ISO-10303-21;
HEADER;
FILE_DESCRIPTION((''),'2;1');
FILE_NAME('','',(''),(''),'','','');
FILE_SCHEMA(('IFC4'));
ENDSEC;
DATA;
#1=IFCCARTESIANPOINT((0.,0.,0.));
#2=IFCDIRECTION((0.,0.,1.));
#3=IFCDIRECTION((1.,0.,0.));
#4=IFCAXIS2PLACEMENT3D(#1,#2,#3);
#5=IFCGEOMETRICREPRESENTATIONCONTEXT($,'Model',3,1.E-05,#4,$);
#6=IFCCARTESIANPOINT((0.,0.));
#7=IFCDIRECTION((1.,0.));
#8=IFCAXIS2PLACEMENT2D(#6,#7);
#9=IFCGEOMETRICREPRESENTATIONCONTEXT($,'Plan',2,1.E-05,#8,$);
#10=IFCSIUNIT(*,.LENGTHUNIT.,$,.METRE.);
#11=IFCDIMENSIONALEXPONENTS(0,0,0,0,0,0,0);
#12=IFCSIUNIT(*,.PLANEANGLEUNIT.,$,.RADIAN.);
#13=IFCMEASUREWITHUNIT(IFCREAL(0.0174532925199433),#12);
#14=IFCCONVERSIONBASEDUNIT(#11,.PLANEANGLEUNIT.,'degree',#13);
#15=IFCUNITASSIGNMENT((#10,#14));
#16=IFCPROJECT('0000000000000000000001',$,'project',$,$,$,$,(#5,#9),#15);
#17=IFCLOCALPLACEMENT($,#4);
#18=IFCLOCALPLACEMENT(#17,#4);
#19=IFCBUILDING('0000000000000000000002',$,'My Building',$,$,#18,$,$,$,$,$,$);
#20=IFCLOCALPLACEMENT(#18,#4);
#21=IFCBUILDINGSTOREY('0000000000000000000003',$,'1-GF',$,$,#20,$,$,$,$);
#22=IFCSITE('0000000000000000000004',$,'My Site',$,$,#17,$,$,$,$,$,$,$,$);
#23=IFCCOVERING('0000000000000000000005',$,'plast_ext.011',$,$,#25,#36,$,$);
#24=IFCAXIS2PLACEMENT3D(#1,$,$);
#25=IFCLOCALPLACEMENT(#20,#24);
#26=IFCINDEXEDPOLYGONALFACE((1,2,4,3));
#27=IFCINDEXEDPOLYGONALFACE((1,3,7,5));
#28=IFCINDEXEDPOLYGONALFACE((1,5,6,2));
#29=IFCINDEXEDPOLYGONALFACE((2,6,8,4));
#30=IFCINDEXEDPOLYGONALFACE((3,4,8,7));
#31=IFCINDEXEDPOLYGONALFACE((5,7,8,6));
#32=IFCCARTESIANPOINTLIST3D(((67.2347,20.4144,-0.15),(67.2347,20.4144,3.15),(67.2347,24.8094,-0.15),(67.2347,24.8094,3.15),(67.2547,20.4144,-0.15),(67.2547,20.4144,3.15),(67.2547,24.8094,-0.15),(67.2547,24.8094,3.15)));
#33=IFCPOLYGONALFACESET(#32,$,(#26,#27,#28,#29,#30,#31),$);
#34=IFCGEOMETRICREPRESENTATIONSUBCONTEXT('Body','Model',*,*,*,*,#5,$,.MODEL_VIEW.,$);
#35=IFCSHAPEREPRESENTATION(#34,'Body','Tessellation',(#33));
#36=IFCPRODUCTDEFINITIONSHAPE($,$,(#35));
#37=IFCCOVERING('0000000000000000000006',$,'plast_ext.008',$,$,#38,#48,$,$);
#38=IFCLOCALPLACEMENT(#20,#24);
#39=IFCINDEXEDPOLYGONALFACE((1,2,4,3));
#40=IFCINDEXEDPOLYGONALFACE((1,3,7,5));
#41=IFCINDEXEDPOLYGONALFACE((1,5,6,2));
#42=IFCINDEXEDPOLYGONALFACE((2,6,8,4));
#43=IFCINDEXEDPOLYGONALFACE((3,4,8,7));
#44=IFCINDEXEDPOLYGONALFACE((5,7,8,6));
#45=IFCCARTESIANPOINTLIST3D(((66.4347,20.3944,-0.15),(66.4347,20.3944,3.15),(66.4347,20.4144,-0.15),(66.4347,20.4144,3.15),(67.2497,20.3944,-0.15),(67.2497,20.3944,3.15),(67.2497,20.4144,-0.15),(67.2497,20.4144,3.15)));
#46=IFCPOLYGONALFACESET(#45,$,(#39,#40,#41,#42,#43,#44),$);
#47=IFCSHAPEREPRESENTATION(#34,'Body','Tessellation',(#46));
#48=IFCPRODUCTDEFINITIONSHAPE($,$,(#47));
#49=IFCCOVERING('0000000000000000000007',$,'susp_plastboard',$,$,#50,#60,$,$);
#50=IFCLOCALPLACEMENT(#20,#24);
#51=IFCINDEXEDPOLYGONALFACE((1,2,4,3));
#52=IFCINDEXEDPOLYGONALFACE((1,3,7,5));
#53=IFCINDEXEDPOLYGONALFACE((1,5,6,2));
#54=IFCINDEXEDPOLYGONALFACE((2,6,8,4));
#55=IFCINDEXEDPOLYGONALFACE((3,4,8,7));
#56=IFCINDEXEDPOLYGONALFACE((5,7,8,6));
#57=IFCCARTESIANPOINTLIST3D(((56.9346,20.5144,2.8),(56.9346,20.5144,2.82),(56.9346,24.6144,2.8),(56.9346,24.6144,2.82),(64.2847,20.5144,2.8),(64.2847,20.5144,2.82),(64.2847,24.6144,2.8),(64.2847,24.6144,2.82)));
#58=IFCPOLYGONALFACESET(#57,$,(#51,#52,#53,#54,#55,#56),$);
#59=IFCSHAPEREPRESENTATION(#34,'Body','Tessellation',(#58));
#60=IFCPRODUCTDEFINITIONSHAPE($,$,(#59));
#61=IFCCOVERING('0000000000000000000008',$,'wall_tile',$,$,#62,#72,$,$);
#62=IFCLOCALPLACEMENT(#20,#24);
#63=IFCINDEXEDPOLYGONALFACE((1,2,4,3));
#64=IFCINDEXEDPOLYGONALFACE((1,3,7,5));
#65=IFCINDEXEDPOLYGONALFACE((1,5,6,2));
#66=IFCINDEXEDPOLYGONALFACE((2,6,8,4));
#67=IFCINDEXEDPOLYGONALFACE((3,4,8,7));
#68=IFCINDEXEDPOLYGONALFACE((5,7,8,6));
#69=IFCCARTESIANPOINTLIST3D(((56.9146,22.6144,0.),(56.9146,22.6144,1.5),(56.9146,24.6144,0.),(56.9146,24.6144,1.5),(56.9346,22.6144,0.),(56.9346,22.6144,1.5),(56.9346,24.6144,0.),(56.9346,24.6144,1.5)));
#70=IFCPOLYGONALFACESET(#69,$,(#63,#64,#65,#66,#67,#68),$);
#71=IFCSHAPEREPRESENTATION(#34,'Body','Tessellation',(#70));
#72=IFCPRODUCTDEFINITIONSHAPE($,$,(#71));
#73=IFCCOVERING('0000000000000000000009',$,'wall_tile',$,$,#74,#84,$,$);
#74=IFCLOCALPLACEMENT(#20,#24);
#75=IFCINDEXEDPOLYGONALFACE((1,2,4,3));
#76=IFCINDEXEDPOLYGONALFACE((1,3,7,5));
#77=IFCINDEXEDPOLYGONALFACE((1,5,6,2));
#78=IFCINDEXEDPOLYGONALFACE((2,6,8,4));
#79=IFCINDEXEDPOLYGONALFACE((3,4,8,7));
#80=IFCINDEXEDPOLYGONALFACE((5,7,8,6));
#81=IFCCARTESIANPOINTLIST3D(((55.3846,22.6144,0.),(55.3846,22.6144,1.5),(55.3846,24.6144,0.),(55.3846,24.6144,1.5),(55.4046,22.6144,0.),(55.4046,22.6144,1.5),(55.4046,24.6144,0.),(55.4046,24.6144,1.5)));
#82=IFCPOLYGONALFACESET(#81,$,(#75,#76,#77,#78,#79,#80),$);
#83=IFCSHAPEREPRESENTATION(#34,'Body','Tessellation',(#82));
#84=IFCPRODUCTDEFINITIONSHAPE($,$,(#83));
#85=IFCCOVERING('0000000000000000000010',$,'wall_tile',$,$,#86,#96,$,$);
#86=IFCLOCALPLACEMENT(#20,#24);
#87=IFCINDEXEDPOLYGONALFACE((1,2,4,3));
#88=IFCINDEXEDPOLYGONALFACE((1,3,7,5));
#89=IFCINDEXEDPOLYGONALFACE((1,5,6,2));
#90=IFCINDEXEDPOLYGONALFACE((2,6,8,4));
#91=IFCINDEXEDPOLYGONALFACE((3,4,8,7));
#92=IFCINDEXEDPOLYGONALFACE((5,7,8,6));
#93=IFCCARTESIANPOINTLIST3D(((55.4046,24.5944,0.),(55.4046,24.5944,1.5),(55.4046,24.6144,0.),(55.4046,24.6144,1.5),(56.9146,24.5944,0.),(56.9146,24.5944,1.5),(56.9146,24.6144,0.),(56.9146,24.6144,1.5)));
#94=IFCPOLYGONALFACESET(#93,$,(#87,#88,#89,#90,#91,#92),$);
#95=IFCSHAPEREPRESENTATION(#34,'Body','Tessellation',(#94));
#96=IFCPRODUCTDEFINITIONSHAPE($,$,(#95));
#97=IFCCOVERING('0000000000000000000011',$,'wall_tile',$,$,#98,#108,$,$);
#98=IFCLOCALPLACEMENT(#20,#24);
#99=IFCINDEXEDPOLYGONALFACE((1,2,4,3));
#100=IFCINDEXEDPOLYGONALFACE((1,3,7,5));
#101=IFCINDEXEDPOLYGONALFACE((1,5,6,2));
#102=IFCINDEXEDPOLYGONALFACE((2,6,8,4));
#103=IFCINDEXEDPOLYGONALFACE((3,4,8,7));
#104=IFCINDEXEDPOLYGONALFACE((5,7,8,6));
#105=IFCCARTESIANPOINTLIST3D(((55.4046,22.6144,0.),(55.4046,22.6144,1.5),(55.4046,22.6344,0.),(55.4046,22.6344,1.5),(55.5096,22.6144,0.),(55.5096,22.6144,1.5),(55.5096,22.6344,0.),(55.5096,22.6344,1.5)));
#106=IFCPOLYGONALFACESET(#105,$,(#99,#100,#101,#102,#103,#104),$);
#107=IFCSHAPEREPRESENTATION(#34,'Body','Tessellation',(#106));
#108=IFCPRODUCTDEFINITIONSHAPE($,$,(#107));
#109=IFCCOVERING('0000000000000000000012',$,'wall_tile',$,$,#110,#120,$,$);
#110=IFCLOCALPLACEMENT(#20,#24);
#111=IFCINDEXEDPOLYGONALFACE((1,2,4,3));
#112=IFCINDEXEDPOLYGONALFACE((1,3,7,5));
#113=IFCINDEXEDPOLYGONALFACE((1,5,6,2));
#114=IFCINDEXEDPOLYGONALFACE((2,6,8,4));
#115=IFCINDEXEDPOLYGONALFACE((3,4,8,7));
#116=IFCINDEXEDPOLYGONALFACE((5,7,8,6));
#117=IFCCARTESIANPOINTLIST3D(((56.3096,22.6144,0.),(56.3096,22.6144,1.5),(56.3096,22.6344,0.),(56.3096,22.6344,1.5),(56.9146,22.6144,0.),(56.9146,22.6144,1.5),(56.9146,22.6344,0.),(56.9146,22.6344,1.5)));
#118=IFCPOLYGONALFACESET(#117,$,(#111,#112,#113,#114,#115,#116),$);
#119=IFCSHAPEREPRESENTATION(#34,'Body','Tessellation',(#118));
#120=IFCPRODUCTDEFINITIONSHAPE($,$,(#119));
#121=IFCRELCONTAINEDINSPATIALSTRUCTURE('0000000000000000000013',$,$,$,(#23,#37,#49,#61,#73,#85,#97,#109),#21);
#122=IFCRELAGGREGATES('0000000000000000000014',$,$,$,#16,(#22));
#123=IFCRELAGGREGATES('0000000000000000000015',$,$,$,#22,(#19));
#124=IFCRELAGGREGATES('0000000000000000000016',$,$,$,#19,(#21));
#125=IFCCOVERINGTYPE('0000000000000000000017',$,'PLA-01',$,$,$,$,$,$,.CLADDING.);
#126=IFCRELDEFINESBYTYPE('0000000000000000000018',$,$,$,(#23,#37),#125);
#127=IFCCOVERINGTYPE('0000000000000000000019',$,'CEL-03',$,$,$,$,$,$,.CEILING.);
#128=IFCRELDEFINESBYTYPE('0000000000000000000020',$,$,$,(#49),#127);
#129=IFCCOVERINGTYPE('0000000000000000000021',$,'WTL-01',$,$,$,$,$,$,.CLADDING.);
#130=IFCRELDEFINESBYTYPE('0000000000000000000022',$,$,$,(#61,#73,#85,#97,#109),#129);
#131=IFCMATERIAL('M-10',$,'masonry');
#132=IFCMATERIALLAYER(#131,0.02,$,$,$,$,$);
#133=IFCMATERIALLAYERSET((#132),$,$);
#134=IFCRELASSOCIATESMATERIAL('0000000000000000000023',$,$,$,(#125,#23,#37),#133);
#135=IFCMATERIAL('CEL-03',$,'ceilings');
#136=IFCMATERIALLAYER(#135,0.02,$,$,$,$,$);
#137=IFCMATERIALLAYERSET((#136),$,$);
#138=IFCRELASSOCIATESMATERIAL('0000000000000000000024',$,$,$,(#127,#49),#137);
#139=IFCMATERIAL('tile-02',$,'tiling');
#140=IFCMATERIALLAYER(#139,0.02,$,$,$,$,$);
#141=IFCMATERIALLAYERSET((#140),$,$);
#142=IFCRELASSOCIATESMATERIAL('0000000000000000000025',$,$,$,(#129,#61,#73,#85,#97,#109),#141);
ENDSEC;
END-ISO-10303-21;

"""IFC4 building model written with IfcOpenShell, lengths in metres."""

from ifc_helpers import new_model, entity, si_unit, converted_unit, frame, origin_with_axes, origin_2d_with_axis, place, context, subcontext, project, spatial, line, indexed_curve, outline, extrude, material, layer, layer_set, layer_usage, type_object, element, save


model = new_model("IFC4")

# Units and contexts
model_context = context("Model", 3, precision=1e-05, world=origin_with_axes())
plan_context = context("Plan", 2, precision=1e-05, world=origin_2d_with_axis())
body_context_1 = subcontext(model_context, "Body", "Model", "MODEL_VIEW")
ifc_project = project(units=[si_unit("LENGTHUNIT", "METRE"), converted_unit("PLANEANGLEUNIT", "degree", entity("IfcReal", 0.0174532925199433), si_unit("PLANEANGLEUNIT", "RADIAN"), dimensions=[0, 0, 0, 0, 0, 0, 0])], contexts=[model_context, plan_context])

# Site, building, storey
site_placement = place(None, origin_with_axes())
site = spatial("IfcSite", under=ifc_project, at=site_placement, Name="My Site")
building_placement = place(site_placement, origin_with_axes())
building = spatial("IfcBuilding", under=site, at=building_placement, Name="My Building")
storey_placement = place(building_placement, origin_with_axes())
storey = spatial("IfcBuildingStorey", under=building, at=storey_placement, Name="1-GF")

# Coverings
ifc_material_1 = material(Name="M-10", Category="masonry")
ifc_layer_1 = layer(ifc_material_1, 0.02)
ifc_layer_set_1 = layer_set([ifc_layer_1])
covering_type_1 = type_object("IfcCoveringType", Name="PLA-01", PredefinedType="CLADDING", material=ifc_layer_set_1)
ifc_layer_usage_1 = layer_usage(ifc_layer_set_1, "AXIS2", "POSITIVE", 0.0)
covering_1_placement = place(storey_placement, frame((67.2547, 20.4144, -0.15), z_axis=(0.0, 0.0, 1.0), x_axis=(0.000001, 1.0, 0.0)))
element("IfcCovering", 1, at=covering_1_placement, inside=storey, type_object=covering_type_1, material=ifc_layer_usage_1, Name="plast_ext.011", context=body_context_1, shape_type="SweptSolid", body=[
    extrude(outline(indexed_curve([(0.0, 0.0), (0.0, 0.02), (4.395, 0.02), (4.395, 0.0), (0.0, 0.0)], self_intersect=False)), origin_with_axes(), (0.0, 0.0, 1.0), 3.3),
])
ifc_layer_usage_2 = layer_usage(ifc_layer_set_1, "AXIS2", "POSITIVE", 0.0)
covering_2_placement = place(storey_placement, frame((67.2497, 20.4144, -0.15), z_axis=(0.0, 0.0, 1.0), x_axis=(-1.0, 0.0, 0.0)))
element("IfcCovering", 2, at=covering_2_placement, inside=storey, type_object=covering_type_1, material=ifc_layer_usage_2, Name="plast_ext.008", context=body_context_1, shape_type="SweptSolid", body=[
    extrude(outline(indexed_curve([(0.0, 0.0), (0.0, 0.02), (0.815, 0.02), (0.815, 0.0), (0.0, 0.0)], self_intersect=False)), origin_with_axes(), (0.0, 0.0, 1.0), 3.3),
])
ifc_material_2 = material(Name="CEL-03", Category="ceilings")
ifc_layer_2 = layer(ifc_material_2, 0.02)
ifc_layer_set_2 = layer_set([ifc_layer_2])
ifc_layer_usage_3 = layer_usage(ifc_layer_set_2, "AXIS3", "POSITIVE", 0.0)
covering_type_2 = type_object("IfcCoveringType", Name="CEL-03", PredefinedType="CEILING", material=ifc_layer_set_2)
covering_3_placement = place(storey_placement, frame((56.9346, 20.5144, 2.8), z_axis=(0.0, 0.0, 1.0), x_axis=(1.0, 0.0, 0.0)))
element("IfcCovering", 3, at=covering_3_placement, inside=storey, type_object=covering_type_2, material=ifc_layer_usage_3, Name="susp_plastboard", context=body_context_1, shape_type="SweptSolid", body=[
    extrude(outline(indexed_curve([(0.0, 0.0), (7.3501, 0.0), (7.3501, 4.1), (0.0, 4.1)], segments=[line(4, 1), line(1, 2), line(2, 3), line(3, 4)], self_intersect=False)), None, (0.0, 0.0, 1.0), 0.02),
])
ifc_material_3 = material(Name="tile-02", Category="tiling")
ifc_layer_3 = layer(ifc_material_3, 0.02)
ifc_layer_set_3 = layer_set([ifc_layer_3])
ifc_layer_usage_4 = layer_usage(ifc_layer_set_3, "AXIS2", "POSITIVE", 0.0)
covering_type_3 = type_object("IfcCoveringType", Name="WTL-01", PredefinedType="CLADDING", material=ifc_layer_set_3)
covering_4_placement = place(storey_placement, frame((56.9346, 22.6144, 0.0), z_axis=(0.0, 0.0, 1.0), x_axis=(0.000001, 1.0, 0.0)))
element("IfcCovering", 4, at=covering_4_placement, inside=storey, type_object=covering_type_3, material=ifc_layer_usage_4, Name="wall_tile", context=body_context_1, shape_type="SweptSolid", body=[
    extrude(outline(indexed_curve([(0.0, 0.0), (0.0, 0.02), (2.0, 0.02), (2.0, 0.0), (0.0, 0.0)], self_intersect=False)), origin_with_axes(), (0.0, 0.0, 1.0), 1.5),
])
ifc_layer_usage_5 = layer_usage(ifc_layer_set_3, "AXIS2", "POSITIVE", 0.0)
covering_5_placement = place(storey_placement, frame((55.4046, 22.6144, 0.0), z_axis=(0.0, 0.0, 1.0), x_axis=(0.000001, 1.0, 0.0)))
element("IfcCovering", 5, at=covering_5_placement, inside=storey, type_object=covering_type_3, material=ifc_layer_usage_5, Name="wall_tile", context=body_context_1, shape_type="SweptSolid", body=[
    extrude(outline(indexed_curve([(0.0, 0.0), (0.0, 0.02), (2.0, 0.02), (2.0, 0.0), (0.0, 0.0)], self_intersect=False)), origin_with_axes(), (0.0, 0.0, 1.0), 1.5),
])
ifc_layer_usage_6 = layer_usage(ifc_layer_set_3, "AXIS2", "POSITIVE", 0.0)
covering_6_placement = place(storey_placement, frame((56.9146, 24.6144, 0.0), z_axis=(0.0, 0.0, 1.0), x_axis=(-1.0, 0.000001, 0.0)))
element("IfcCovering", 6, at=covering_6_placement, inside=storey, type_object=covering_type_3, material=ifc_layer_usage_6, Name="wall_tile", context=body_context_1, shape_type="SweptSolid", body=[
    extrude(outline(indexed_curve([(0.0, 0.0), (0.0, 0.02), (1.51, 0.02), (1.51, 0.0), (0.0, 0.0)], self_intersect=False)), origin_with_axes(), (0.0, 0.0, 1.0), 1.5),
])
ifc_layer_usage_7 = layer_usage(ifc_layer_set_3, "AXIS2", "POSITIVE", 0.0)
covering_7_placement = place(storey_placement, frame((55.4046, 22.6144, 0.0), z_axis=(0.0, 0.0, 1.0), x_axis=(1.0, -0.000001, 0.0)))
element("IfcCovering", 7, at=covering_7_placement, inside=storey, type_object=covering_type_3, material=ifc_layer_usage_7, Name="wall_tile", context=body_context_1, shape_type="SweptSolid", body=[
    extrude(outline(indexed_curve([(0.0, 0.0), (0.0, 0.02), (0.105, 0.02), (0.105, 0.0), (0.0, 0.0)], self_intersect=False)), origin_with_axes(), (0.0, 0.0, 1.0), 1.5),
])
ifc_layer_usage_8 = layer_usage(ifc_layer_set_3, "AXIS2", "POSITIVE", 0.0)
covering_8_placement = place(storey_placement, frame((56.3096, 22.6144, 0.0), z_axis=(0.0, 0.0, 1.0), x_axis=(1.0, -0.000001, 0.0)))
element("IfcCovering", 8, at=covering_8_placement, inside=storey, type_object=covering_type_3, material=ifc_layer_usage_8, Name="wall_tile", context=body_context_1, shape_type="SweptSolid", body=[
    extrude(outline(indexed_curve([(0.0, 0.0), (0.0, 0.02), (0.605, 0.02), (0.605, 0.0), (0.0, 0.0)], self_intersect=False)), origin_with_axes(), (0.0, 0.0, 1.0), 1.5),
])

save(model, "model.ifc")
